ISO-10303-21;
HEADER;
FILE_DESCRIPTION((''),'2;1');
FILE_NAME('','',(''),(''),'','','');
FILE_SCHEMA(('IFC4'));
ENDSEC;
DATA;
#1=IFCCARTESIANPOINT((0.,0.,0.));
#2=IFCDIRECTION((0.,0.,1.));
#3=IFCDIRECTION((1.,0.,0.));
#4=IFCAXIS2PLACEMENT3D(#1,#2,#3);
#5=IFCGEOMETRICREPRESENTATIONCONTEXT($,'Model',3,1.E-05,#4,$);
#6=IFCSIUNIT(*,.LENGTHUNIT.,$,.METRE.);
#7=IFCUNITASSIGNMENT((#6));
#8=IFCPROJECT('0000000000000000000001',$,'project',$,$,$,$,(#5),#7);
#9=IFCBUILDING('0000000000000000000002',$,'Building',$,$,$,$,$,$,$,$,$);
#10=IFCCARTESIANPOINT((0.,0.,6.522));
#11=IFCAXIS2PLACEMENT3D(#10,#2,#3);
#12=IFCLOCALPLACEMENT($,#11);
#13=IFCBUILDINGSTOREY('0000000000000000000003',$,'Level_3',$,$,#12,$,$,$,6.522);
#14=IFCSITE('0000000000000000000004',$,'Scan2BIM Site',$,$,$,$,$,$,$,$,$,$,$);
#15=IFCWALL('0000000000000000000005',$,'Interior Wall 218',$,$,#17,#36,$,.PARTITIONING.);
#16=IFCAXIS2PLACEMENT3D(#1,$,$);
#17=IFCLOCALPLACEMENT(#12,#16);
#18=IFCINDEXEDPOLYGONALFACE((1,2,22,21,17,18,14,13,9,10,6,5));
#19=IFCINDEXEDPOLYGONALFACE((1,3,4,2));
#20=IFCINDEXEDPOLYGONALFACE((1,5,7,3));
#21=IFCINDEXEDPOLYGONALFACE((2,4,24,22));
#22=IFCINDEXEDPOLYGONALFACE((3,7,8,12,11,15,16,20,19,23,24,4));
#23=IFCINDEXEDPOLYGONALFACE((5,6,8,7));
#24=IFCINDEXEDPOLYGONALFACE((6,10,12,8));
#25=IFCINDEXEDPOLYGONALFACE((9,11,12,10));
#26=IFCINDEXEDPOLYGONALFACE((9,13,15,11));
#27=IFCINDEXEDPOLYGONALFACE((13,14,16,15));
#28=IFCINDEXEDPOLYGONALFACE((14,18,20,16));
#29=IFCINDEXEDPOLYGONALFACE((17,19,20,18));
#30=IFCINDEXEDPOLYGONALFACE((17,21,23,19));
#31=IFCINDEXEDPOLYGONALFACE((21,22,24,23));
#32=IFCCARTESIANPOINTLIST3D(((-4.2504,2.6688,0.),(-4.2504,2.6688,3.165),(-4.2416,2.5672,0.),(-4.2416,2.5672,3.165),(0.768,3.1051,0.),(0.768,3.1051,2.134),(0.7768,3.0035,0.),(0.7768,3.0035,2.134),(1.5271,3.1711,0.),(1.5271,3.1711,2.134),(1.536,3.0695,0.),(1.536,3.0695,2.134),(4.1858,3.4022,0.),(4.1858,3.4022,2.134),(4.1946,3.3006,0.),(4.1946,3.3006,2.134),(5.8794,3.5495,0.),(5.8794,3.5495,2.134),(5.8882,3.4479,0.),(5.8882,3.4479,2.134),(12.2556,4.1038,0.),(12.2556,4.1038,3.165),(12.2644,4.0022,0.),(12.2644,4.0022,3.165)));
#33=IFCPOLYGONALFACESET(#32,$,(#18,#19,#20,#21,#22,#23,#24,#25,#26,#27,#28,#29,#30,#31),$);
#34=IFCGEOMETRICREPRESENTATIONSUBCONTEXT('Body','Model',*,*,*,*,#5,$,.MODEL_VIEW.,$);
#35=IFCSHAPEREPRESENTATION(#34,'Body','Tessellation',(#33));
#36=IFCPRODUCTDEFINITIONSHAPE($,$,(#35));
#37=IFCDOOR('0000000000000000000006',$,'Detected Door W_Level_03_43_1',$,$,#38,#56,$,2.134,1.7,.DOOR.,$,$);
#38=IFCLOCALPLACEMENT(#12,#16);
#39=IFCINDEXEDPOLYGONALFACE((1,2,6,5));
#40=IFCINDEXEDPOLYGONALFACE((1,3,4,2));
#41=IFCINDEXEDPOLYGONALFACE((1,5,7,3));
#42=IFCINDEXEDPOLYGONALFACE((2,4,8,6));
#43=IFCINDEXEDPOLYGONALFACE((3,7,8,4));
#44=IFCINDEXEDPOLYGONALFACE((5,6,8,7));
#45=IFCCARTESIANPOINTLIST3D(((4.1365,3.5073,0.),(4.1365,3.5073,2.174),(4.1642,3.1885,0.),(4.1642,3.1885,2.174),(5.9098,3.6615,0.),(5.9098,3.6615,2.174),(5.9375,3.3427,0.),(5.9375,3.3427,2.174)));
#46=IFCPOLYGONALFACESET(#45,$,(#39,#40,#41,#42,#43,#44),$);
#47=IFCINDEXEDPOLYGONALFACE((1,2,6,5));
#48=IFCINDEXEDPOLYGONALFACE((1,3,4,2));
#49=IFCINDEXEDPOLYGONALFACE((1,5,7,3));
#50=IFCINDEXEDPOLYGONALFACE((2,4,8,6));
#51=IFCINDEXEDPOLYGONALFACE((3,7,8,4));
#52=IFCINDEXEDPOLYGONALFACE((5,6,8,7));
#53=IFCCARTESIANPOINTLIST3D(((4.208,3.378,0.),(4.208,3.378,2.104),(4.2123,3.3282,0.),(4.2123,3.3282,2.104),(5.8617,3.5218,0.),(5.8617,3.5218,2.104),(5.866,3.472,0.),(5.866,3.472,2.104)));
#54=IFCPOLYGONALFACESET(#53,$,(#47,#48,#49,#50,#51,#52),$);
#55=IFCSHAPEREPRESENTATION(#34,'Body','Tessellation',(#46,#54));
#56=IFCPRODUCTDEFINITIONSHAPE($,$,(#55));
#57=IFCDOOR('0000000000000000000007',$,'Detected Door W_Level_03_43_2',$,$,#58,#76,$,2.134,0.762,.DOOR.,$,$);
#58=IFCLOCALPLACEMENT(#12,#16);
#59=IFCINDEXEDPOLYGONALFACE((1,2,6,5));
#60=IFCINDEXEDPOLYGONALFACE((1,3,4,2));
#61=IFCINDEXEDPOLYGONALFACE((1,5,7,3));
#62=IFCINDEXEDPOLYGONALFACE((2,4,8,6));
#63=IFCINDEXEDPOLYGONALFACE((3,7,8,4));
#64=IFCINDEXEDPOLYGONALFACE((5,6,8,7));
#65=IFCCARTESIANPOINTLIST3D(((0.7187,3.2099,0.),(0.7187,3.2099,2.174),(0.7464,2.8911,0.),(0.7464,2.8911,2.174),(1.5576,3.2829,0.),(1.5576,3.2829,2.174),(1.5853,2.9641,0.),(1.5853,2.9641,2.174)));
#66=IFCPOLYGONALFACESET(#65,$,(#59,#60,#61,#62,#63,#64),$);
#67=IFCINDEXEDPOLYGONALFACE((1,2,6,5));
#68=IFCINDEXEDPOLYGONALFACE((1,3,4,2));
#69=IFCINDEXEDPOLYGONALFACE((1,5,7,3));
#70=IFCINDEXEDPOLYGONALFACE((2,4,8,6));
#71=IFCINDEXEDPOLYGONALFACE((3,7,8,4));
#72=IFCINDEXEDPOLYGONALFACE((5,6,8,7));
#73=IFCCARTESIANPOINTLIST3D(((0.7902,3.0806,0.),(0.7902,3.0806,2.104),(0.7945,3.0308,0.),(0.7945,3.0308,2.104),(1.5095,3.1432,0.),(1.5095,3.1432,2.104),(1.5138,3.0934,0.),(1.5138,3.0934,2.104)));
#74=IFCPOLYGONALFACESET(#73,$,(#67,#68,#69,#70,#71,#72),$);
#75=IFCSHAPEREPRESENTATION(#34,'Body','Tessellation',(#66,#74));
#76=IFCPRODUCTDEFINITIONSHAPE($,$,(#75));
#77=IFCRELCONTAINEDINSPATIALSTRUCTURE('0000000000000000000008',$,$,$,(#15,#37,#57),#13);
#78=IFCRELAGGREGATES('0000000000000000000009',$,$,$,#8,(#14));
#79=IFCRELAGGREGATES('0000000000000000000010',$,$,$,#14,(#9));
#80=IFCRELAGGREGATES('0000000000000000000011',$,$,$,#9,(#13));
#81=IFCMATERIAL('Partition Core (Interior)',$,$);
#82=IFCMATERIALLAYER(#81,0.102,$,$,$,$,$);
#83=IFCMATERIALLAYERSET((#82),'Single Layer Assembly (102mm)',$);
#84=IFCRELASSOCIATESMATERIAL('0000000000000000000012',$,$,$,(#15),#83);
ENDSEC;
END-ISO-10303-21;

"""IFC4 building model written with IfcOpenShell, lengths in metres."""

from ifc_helpers import new_model, si_unit, frame, origin, origin_with_axes, place, context, subcontext, project, spatial, rectangle, extrude, material, layer, layer_set, element, fill, save


model = new_model("IFC4")

# Units and contexts
model_context = context("Model", 3, precision=1e-05, world=origin_with_axes())
body_context = subcontext(model_context, "Body", "Model", "MODEL_VIEW")
ifc_project = project(units=[si_unit("LENGTHUNIT", "METRE")], contexts=[model_context])

# Site, building, storey
site = spatial("IfcSite", under=ifc_project, Name="Scan2BIM Site")
building = spatial("IfcBuilding", under=site, Name="Building")
storey_placement = place(None, frame((0.0, 0.0, 6.522), z_axis=(0.0, 0.0, 1.0), x_axis=(1.0, 0.0, 0.0)))
storey = spatial("IfcBuildingStorey", under=building, at=storey_placement, Name="Level_3", Elevation=6.522)

# Wall, openings, doors
ifc_material_1 = material(Name="Partition Core (Interior)")
ifc_layer_1 = layer(ifc_material_1, 0.102)
ifc_layer_set_1 = layer_set([ifc_layer_1], Name="Single Layer Assembly (102mm)")
wall_1_placement = place(storey_placement, frame((4.007, 3.3355, 0.0), z_axis=(0.0, 0.0, 1.0), x_axis=(-0.996242, -0.086611, 0.0)))
wall_1 = element("IfcWall", 1, at=wall_1_placement, inside=storey, material=ifc_layer_set_1, Name="Interior Wall 218", PredefinedType="PARTITIONING", context=body_context, shape_type="SweptSolid", body=[
    extrude(rectangle(XDim=16.5683, YDim=0.102), origin(), (0.0, 0.0, 1.0), 3.165),
])
opening_1_placement = place(None, frame((5.037, 3.425, 6.522), z_axis=(0.0, 0.0, 1.0), x_axis=(-0.996242, -0.086611, 0.0)))
opening_1 = element("IfcOpeningElement", 2, at=opening_1_placement, cuts=wall_1, PredefinedType="OPENING", context=body_context, shape_type="SweptSolid", body=[
    extrude(rectangle(XDim=1.7, YDim=0.202), origin(), (0.0, 0.0, 1.0), 2.134),
])
opening_2_placement = place(None, frame((1.152, 3.087, 6.522), z_axis=(0.0, 0.0, 1.0), x_axis=(-0.996242, -0.086611, 0.0)))
opening_2 = element("IfcOpeningElement", 3, at=opening_2_placement, cuts=wall_1, PredefinedType="OPENING", context=body_context, shape_type="SweptSolid", body=[
    extrude(rectangle(XDim=0.762, YDim=0.202), origin(), (0.0, 0.0, 1.0), 2.134),
])
door_1_placement = place(opening_1_placement, frame((0.0, 0.0, 0.0), z_axis=(0.0, 0.0, 1.0), x_axis=(1.0, 0.0, 0.0)))
door_1 = element("IfcDoor", 4, at=door_1_placement, inside=storey, Name="Detected Door W_Level_03_43_1", OverallHeight=2.134, OverallWidth=1.7, PredefinedType="DOOR", context=body_context, shape_type="SweptSolid", body=[
    extrude(rectangle(XDim=1.78, YDim=0.32), origin(), (0.0, 0.0, 1.0), 2.174),
    extrude(rectangle(XDim=1.66, YDim=0.05), origin(), (0.0, 0.0, 1.0), 2.104),
])
fill(opening_1, door_1)
door_2_placement = place(opening_2_placement, frame((0.0, 0.0, 0.0), z_axis=(0.0, 0.0, 1.0), x_axis=(1.0, 0.0, 0.0)))
door_2 = element("IfcDoor", 5, at=door_2_placement, inside=storey, Name="Detected Door W_Level_03_43_2", OverallHeight=2.134, OverallWidth=0.762, PredefinedType="DOOR", context=body_context, shape_type="SweptSolid", body=[
    extrude(rectangle(XDim=0.842, YDim=0.32), origin(), (0.0, 0.0, 1.0), 2.174),
    extrude(rectangle(XDim=0.722, YDim=0.05), origin(), (0.0, 0.0, 1.0), 2.104),
])
fill(opening_2, door_2)

save(model, "model.ifc")
